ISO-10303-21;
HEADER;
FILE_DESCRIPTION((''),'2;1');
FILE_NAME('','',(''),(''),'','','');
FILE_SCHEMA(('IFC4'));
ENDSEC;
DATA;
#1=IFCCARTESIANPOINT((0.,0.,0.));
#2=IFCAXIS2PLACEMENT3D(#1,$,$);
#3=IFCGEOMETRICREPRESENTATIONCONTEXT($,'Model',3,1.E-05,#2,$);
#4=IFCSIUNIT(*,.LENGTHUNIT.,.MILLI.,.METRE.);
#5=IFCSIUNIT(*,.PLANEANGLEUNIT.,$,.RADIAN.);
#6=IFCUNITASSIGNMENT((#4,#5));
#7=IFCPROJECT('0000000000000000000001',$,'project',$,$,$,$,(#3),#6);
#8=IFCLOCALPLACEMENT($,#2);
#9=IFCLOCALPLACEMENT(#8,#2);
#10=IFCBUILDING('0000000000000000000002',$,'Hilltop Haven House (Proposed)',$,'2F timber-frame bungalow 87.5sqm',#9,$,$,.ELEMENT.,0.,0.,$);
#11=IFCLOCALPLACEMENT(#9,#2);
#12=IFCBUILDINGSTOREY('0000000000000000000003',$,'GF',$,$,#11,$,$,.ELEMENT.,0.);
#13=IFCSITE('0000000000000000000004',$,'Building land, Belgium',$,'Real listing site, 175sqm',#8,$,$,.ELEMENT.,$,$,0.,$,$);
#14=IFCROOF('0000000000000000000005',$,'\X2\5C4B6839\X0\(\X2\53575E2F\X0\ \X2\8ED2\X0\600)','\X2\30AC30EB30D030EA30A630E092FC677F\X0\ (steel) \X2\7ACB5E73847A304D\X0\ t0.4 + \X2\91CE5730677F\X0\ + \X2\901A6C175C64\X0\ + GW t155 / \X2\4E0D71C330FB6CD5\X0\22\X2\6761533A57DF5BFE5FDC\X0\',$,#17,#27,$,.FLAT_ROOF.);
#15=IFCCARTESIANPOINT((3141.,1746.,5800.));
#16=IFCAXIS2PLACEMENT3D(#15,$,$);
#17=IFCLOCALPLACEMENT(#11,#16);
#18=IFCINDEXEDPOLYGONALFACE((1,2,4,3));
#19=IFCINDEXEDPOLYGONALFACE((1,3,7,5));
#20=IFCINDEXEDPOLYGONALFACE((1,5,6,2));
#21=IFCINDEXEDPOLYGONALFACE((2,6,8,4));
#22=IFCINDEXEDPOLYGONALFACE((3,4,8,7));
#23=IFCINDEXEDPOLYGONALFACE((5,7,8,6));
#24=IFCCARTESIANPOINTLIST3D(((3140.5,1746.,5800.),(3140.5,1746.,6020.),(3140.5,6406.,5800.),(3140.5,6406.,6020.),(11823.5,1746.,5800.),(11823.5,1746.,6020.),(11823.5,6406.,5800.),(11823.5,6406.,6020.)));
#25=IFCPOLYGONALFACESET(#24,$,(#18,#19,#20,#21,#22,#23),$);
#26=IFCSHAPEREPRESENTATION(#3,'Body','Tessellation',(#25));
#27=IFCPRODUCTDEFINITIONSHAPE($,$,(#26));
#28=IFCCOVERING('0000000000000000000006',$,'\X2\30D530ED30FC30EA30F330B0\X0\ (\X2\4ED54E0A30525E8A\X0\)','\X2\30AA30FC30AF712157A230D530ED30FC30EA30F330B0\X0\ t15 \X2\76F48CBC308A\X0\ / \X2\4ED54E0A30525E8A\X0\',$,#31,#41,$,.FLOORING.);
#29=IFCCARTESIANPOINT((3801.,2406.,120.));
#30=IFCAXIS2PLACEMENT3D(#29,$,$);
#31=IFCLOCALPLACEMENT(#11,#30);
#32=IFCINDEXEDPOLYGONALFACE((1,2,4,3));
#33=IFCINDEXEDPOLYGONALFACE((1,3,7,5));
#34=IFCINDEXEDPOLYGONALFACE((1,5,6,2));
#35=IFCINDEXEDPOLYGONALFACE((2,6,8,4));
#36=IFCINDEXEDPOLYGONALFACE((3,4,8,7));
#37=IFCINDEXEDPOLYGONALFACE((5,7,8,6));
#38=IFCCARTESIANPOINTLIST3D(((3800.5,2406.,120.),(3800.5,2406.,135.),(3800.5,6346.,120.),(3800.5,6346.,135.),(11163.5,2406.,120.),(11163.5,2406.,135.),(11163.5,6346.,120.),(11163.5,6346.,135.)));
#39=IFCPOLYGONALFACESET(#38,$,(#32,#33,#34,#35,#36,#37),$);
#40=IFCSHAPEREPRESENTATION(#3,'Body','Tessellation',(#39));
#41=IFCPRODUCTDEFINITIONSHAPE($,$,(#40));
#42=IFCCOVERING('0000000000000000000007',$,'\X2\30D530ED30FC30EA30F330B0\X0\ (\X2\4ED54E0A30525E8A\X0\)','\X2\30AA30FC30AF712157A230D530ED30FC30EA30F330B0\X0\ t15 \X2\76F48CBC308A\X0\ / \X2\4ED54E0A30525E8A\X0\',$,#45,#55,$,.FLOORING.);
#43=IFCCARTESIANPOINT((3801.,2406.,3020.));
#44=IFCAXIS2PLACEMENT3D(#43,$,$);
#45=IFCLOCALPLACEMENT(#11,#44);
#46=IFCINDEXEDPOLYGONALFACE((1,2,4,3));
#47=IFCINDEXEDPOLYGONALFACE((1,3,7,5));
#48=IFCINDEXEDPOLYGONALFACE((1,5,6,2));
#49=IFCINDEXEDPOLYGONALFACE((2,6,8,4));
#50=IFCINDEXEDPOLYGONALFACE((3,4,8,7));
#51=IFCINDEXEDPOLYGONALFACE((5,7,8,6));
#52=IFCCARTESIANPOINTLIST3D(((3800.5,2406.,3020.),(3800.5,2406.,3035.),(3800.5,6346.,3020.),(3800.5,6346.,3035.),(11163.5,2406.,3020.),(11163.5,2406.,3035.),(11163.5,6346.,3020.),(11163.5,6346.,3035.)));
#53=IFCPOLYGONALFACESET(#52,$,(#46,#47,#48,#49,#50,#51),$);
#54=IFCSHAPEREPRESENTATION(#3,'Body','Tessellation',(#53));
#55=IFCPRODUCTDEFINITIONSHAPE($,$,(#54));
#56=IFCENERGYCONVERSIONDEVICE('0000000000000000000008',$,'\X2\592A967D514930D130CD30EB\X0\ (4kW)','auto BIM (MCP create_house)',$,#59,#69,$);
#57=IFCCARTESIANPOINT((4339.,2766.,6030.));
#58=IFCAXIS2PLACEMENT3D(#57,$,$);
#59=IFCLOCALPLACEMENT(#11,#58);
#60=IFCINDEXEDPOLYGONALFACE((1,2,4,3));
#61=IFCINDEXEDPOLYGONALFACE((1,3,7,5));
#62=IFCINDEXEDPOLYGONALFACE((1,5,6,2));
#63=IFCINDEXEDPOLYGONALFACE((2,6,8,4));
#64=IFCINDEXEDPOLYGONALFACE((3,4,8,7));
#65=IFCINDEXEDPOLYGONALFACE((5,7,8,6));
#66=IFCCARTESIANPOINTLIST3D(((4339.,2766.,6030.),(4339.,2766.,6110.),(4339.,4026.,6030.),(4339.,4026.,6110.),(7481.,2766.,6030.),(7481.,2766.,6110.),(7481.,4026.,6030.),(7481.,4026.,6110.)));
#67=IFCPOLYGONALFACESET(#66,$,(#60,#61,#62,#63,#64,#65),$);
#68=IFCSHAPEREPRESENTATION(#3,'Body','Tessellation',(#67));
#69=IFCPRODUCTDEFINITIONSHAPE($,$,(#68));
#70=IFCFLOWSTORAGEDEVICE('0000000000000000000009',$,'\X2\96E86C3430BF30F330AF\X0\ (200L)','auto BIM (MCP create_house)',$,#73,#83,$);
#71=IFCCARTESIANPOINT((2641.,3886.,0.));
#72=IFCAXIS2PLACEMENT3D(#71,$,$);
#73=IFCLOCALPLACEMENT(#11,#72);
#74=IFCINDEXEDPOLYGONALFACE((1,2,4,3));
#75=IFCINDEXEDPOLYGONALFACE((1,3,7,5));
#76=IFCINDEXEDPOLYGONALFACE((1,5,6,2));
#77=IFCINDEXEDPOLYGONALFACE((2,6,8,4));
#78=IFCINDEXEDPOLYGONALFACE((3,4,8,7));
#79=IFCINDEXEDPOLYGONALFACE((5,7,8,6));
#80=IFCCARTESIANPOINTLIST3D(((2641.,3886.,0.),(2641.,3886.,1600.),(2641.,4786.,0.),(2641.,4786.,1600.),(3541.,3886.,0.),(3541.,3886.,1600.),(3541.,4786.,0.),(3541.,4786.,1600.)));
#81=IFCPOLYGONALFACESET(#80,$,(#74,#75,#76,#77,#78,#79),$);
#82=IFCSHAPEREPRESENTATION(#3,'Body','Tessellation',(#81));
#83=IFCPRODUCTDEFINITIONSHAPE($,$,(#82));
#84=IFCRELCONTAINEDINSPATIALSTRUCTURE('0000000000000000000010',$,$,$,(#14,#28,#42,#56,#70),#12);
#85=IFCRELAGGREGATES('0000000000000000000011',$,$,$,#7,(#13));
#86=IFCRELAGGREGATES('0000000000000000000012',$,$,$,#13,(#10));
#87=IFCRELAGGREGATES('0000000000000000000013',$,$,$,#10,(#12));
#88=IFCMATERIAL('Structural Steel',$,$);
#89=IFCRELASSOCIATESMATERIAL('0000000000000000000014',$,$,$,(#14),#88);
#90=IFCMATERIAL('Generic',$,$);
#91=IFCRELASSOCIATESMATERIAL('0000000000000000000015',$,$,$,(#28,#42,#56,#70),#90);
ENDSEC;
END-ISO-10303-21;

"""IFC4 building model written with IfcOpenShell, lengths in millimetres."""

from ifc_helpers import new_model, si_unit, frame, frame_2d, origin, place, context, project, spatial, rectangle, extrude, material, element, save


model = new_model("IFC4")

# Units and contexts
model_context = context("Model", 3, precision=1e-05, world=origin())
ifc_project = project(units=[si_unit("LENGTHUNIT", "METRE", prefix="MILLI"), si_unit("PLANEANGLEUNIT", "RADIAN")], contexts=[model_context])

# Site, building, storey
site_placement = place(None, origin())
site = spatial("IfcSite", under=ifc_project, at=site_placement, Name="Building land, Belgium", ObjectType="Real listing site, 175sqm", CompositionType="ELEMENT", RefElevation=0.0)
building_placement = place(site_placement, origin())
building = spatial("IfcBuilding", under=site, at=building_placement, Name="Hilltop Haven House (Proposed)", ObjectType="2F timber-frame bungalow 87.5sqm", CompositionType="ELEMENT", ElevationOfRefHeight=0.0, ElevationOfTerrain=0.0)
storey_placement = place(building_placement, origin())
storey = spatial("IfcBuildingStorey", under=building, at=storey_placement, Name="GF", CompositionType="ELEMENT", Elevation=0.0)

# Roof
ifc_material_1 = material(Name="Structural Steel")
for number, where, name in (
    (1, (3141.0, 1746.0, 5800.0), "屋根(南帯 軒600)"),
):
    element("IfcRoof", number, at=place(storey_placement, frame(where)), inside=storey, material=ifc_material_1, Name=name, Description="ガルバリウム鋼板 (steel) 立平葺き t0.4 + 野地板 + 通気層 + GW t155 / 不燃・法22条区域対応", PredefinedType="FLAT_ROOF", context=model_context, shape_type="SweptSolid", body=[
        extrude(rectangle(XDim=8683.0, YDim=4660.0, at=frame_2d((4341.0, 2330.0))), frame((3141.0, 1746.0, 5800.0)), (0.0, 0.0, 1.0), 220.0),
    ])

# Coverings
ifc_material_2 = material(Name="Generic")
covering_1_placement = place(storey_placement, frame((3801.0, 2406.0, 120.0)))
element("IfcCovering", 2, at=covering_1_placement, inside=storey, material=ifc_material_2, Name="フローリング (仕上げ床)", Description="オーク無垢フローリング t15 直貼り / 仕上げ床", PredefinedType="FLOORING", context=model_context, shape_type="SweptSolid", body=[
    extrude(rectangle(XDim=7363.0, YDim=3940.0, at=frame_2d((3681.0, 1970.0))), frame((3801.0, 2406.0, 120.0)), (0.0, 0.0, 1.0), 15.0),
])
covering_2_placement = place(storey_placement, frame((3801.0, 2406.0, 3020.0)))
element("IfcCovering", 3, at=covering_2_placement, inside=storey, material=ifc_material_2, Name="フローリング (仕上げ床)", Description="オーク無垢フローリング t15 直貼り / 仕上げ床", PredefinedType="FLOORING", context=model_context, shape_type="SweptSolid", body=[
    extrude(rectangle(XDim=7363.0, YDim=3940.0, at=frame_2d((3681.0, 1970.0))), frame((3801.0, 2406.0, 3020.0)), (0.0, 0.0, 1.0), 15.0),
])

# Energy conversion device
energy_conversion_device_placement = place(storey_placement, frame((4339.0, 2766.0, 6030.0)))
element("IfcEnergyConversionDevice", 4, at=energy_conversion_device_placement, inside=storey, material=ifc_material_2, Name="太陽光パネル (4kW)", Description="auto BIM (MCP create_house)", context=model_context, shape_type="SweptSolid", body=[
    extrude(rectangle(XDim=3142.0, YDim=1260.0, at=frame_2d((1571.0, 630.0))), frame((4339.0, 2766.0, 6030.0)), (0.0, 0.0, 1.0), 80.0),
])

# Flow storage device
flow_storage_device_placement = place(storey_placement, frame((2641.0, 3886.0, 0.0)))
element("IfcFlowStorageDevice", 5, at=flow_storage_device_placement, inside=storey, material=ifc_material_2, Name="雨水タンク (200L)", Description="auto BIM (MCP create_house)", context=model_context, shape_type="SweptSolid", body=[
    extrude(rectangle(XDim=900.0, YDim=900.0, at=frame_2d((450.0, 450.0))), frame((2641.0, 3886.0, 0.0)), (0.0, 0.0, 1.0), 1600.0),
])

save(model, "model.ifc")
